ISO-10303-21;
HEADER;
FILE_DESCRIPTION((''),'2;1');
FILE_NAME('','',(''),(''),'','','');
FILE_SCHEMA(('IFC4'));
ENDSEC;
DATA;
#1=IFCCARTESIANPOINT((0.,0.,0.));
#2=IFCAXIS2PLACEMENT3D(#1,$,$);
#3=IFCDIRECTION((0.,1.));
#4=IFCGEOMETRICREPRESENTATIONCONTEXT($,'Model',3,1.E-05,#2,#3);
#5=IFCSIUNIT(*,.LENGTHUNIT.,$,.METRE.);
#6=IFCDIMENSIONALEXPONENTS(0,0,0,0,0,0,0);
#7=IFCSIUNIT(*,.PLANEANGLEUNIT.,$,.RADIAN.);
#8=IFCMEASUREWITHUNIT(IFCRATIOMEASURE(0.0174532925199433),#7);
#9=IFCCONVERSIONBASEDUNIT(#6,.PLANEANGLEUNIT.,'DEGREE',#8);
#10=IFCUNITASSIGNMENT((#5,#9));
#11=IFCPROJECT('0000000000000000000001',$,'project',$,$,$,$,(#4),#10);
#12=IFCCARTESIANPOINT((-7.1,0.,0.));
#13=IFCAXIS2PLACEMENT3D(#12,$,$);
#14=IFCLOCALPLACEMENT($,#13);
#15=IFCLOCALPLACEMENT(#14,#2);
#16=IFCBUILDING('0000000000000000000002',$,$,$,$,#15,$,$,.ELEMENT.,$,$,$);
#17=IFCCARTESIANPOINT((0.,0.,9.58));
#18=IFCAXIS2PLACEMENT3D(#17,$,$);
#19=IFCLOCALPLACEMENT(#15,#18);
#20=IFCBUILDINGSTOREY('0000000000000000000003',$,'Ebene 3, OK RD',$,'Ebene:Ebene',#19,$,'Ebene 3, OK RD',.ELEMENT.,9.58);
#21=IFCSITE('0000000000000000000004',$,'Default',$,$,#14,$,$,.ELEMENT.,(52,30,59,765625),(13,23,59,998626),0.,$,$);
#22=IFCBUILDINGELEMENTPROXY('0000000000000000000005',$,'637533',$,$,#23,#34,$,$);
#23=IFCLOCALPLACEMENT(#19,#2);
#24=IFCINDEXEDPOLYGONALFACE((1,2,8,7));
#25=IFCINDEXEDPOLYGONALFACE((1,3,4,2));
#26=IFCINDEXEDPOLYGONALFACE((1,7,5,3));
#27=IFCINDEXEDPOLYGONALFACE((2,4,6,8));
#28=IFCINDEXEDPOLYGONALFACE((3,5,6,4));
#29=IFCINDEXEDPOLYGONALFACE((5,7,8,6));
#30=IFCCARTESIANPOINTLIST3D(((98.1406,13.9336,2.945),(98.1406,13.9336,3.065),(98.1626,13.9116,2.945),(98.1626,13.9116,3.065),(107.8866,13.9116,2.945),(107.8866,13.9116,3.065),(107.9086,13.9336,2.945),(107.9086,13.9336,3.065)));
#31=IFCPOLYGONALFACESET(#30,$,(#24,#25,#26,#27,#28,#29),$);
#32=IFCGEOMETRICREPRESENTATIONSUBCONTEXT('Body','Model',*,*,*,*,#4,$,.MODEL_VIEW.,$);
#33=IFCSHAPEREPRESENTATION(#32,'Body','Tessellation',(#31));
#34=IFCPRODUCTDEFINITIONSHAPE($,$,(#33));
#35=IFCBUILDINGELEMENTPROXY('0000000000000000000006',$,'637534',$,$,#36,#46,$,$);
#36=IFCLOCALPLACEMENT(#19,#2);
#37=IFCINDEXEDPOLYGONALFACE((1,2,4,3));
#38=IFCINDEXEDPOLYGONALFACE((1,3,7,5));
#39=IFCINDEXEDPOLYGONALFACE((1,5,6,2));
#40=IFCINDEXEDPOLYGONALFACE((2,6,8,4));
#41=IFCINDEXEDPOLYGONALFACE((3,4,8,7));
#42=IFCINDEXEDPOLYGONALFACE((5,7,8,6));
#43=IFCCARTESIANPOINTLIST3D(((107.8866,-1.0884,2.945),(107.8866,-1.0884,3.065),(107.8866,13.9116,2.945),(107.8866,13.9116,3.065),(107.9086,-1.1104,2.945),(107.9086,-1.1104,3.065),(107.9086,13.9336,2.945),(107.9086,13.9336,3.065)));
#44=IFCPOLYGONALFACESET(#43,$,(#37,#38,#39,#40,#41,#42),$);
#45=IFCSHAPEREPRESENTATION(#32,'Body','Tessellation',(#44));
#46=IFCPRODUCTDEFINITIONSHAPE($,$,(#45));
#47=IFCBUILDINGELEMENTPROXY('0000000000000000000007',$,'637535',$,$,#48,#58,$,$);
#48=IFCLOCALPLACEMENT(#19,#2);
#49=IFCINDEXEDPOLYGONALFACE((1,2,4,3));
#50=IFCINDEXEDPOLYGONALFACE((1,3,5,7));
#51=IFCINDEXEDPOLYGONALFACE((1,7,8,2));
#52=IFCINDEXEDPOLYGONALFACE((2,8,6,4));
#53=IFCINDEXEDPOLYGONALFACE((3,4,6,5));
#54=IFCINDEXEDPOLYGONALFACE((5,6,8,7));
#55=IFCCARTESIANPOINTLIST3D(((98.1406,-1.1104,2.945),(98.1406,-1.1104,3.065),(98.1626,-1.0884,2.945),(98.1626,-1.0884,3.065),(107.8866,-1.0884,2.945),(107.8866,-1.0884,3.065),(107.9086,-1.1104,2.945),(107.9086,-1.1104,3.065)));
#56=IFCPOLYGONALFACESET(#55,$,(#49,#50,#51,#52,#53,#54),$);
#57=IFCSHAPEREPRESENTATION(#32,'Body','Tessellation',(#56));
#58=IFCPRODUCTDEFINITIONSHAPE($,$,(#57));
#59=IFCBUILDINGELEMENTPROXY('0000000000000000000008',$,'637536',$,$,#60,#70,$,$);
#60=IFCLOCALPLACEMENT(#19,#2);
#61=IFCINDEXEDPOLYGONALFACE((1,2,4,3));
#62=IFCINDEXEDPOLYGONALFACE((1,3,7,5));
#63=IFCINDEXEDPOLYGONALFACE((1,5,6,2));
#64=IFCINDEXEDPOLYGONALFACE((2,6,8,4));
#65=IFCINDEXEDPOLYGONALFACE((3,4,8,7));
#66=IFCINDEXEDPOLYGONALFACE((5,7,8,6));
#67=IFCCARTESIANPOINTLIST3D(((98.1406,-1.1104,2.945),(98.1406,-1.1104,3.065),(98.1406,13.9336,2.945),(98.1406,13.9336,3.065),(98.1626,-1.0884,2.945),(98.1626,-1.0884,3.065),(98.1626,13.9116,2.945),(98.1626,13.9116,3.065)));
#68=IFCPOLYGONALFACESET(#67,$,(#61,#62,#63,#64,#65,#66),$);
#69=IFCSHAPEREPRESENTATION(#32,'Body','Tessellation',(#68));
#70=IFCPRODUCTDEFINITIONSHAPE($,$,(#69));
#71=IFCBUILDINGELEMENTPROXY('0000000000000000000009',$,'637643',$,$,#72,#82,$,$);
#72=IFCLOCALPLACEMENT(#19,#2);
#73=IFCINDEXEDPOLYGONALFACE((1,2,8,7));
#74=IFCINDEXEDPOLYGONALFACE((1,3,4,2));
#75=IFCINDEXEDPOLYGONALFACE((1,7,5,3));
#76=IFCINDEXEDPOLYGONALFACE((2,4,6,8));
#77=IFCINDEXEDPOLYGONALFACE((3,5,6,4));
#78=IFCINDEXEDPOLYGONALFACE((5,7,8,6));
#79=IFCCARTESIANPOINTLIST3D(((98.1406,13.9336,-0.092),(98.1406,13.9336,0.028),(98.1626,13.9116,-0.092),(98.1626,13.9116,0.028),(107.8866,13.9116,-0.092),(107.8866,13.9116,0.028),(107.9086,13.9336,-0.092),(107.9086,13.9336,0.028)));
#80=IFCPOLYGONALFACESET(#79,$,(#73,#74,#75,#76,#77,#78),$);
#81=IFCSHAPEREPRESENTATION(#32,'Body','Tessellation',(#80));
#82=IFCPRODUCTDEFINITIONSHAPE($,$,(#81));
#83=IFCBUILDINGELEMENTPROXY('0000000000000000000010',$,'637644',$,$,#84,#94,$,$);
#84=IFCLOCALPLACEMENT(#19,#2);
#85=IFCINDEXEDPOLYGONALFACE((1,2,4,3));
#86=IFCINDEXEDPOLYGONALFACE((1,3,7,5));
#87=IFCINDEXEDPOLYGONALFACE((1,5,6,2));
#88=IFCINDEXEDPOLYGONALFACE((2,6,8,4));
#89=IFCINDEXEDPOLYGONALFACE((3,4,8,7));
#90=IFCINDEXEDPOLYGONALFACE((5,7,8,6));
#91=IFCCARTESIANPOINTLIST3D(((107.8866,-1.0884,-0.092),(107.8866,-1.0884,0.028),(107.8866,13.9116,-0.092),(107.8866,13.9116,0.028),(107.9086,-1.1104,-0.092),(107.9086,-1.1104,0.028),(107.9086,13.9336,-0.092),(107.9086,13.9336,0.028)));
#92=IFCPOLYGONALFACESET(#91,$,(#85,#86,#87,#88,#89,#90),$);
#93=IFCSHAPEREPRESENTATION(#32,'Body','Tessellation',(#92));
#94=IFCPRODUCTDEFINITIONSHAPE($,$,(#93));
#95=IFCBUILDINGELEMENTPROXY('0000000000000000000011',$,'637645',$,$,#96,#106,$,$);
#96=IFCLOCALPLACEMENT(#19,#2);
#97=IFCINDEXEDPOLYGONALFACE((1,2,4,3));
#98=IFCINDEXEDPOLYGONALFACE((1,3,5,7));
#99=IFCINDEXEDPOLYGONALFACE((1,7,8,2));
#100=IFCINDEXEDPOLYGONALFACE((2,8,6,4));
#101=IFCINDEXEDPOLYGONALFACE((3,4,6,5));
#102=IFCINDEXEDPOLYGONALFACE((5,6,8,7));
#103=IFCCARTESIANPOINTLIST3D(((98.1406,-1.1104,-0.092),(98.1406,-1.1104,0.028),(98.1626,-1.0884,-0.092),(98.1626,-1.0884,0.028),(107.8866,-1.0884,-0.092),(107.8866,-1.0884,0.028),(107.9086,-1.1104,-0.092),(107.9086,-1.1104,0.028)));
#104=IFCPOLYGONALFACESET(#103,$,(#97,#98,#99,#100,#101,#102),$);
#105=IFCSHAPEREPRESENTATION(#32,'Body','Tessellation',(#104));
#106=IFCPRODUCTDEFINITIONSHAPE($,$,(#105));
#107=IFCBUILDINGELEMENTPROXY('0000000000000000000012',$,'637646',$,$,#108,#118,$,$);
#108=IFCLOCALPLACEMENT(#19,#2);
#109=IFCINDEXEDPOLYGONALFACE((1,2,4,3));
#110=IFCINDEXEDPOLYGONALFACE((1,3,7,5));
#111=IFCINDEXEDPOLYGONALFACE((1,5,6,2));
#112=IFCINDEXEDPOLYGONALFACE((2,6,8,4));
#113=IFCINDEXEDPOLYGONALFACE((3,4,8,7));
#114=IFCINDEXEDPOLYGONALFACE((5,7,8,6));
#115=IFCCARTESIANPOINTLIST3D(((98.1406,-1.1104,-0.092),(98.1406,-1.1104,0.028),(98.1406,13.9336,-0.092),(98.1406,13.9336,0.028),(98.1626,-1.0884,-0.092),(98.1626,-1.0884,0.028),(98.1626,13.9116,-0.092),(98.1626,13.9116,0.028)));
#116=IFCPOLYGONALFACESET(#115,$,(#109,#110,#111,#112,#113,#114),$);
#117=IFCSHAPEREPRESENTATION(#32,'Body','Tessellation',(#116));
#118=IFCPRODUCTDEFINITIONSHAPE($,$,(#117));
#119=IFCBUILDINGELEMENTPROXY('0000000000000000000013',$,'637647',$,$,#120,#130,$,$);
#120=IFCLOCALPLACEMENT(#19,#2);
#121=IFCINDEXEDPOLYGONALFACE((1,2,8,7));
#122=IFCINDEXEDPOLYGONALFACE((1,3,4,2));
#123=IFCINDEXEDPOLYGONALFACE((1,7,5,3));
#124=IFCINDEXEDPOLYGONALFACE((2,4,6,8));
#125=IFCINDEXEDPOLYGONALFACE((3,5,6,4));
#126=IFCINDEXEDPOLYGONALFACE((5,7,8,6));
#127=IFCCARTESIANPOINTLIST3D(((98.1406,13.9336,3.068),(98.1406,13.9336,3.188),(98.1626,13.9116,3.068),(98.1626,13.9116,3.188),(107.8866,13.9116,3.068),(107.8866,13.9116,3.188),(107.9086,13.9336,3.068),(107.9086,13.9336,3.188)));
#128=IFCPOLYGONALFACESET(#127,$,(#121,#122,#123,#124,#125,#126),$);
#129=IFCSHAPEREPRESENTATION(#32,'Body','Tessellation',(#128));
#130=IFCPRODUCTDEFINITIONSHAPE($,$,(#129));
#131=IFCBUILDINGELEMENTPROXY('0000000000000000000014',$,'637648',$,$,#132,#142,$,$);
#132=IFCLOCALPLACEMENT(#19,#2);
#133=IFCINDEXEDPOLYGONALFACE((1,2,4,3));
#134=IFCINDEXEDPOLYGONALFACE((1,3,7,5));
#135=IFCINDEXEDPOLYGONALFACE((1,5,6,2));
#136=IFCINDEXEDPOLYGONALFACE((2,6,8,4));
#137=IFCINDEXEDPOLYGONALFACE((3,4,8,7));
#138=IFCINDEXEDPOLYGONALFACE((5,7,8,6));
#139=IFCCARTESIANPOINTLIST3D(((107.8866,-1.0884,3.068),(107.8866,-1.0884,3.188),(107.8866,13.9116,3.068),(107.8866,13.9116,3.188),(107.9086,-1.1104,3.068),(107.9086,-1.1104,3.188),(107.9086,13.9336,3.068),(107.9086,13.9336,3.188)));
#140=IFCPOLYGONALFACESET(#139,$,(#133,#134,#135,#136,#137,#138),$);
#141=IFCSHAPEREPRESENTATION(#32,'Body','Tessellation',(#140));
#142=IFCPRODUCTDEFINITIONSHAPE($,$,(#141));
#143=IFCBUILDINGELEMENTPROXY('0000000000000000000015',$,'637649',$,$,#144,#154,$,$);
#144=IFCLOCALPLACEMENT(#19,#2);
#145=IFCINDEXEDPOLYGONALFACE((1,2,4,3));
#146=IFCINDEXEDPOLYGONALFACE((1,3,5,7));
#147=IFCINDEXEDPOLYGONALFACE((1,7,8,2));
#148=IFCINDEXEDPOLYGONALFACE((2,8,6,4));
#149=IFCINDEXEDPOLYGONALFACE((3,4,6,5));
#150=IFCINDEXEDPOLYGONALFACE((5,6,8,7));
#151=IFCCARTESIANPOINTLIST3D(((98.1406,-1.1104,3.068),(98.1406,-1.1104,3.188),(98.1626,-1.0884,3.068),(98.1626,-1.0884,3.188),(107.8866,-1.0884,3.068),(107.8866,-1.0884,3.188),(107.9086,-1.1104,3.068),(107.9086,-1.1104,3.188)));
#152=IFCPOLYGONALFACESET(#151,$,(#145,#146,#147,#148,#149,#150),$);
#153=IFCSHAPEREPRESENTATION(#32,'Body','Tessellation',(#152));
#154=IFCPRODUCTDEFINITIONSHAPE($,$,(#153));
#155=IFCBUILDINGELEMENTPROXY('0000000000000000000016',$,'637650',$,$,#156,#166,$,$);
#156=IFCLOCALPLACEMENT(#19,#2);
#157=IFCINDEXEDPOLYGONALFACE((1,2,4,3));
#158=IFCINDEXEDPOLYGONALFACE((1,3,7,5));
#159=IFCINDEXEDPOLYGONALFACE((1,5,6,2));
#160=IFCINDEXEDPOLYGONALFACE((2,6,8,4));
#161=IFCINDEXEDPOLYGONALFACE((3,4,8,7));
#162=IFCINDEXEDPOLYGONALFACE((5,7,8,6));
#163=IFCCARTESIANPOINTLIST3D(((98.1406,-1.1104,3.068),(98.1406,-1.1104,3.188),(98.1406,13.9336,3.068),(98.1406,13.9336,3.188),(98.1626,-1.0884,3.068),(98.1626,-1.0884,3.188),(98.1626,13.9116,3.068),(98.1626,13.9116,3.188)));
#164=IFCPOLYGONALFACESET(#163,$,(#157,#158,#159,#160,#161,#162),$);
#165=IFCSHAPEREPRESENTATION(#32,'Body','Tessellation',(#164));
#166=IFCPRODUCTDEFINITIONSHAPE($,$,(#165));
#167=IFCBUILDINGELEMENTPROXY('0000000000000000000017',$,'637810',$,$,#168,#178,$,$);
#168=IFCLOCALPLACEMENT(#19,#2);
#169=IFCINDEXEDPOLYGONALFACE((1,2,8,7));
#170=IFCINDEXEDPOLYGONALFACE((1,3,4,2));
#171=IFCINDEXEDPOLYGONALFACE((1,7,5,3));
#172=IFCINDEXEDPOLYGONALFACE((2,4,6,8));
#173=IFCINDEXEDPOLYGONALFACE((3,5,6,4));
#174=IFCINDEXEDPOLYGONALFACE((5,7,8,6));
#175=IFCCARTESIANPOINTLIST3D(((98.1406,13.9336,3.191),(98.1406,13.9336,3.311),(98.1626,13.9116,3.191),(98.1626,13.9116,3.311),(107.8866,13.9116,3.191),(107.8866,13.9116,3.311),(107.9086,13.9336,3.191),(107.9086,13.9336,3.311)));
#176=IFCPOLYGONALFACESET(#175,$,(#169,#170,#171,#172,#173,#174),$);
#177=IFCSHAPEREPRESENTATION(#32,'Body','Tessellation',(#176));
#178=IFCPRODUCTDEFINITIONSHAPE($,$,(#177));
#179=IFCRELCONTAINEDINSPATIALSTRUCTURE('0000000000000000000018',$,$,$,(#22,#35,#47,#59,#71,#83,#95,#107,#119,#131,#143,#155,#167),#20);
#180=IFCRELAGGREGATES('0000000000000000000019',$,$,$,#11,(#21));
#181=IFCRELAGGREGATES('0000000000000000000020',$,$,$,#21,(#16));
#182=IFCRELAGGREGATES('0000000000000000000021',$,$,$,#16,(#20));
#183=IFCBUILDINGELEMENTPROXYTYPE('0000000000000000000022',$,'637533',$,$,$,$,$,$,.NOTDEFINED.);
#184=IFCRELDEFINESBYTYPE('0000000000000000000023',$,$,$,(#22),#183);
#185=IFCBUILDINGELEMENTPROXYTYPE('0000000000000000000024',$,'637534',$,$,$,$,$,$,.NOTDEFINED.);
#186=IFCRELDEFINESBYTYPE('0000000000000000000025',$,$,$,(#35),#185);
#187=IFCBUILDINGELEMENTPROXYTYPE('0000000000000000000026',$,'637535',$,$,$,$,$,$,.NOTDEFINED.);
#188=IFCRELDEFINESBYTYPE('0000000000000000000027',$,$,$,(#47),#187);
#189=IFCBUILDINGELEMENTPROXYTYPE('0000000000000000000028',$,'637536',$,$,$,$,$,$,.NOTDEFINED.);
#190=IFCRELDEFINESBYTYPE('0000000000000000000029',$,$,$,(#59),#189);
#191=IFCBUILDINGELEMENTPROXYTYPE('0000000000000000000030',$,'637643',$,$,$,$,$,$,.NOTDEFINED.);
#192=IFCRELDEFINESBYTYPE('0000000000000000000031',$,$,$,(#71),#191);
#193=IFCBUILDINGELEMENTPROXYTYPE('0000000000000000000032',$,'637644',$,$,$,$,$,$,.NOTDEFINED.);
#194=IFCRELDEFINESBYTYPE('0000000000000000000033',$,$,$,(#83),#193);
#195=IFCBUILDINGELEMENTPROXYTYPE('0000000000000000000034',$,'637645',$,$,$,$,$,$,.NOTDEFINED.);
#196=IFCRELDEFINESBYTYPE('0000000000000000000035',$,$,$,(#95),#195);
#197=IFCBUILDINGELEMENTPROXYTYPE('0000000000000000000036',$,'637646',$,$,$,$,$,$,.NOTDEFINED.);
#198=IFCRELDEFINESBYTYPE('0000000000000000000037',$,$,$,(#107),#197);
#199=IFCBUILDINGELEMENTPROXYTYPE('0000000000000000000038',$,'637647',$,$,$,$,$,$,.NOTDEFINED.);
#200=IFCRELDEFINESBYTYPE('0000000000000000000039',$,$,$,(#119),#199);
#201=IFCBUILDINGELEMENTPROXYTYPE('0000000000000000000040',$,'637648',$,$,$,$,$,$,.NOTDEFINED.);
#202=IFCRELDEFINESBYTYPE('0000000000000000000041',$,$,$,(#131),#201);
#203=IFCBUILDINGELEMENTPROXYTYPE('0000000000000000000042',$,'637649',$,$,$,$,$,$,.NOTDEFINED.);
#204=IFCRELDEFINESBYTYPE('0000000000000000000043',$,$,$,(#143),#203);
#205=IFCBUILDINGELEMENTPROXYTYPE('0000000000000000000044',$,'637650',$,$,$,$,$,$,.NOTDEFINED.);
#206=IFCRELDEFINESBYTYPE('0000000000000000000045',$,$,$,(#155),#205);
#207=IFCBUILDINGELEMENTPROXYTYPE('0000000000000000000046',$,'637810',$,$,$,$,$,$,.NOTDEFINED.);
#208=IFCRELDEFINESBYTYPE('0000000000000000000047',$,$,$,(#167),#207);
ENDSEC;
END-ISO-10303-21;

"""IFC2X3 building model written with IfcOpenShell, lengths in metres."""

from ifc_helpers import new_model, entity, si_unit, converted_unit, direction, frame, origin, place, context, subcontext, project, spatial, polyline, outline, extrude, type_object, element, save


model = new_model("IFC2X3")

# Units and contexts
model_context = context("Model", 3, precision=1e-05, world=origin(), true_north=direction((0.0, 1.0)))
body_context = subcontext(model_context, "Body", "Model", "MODEL_VIEW")
ifc_project = project(units=[si_unit("LENGTHUNIT", "METRE"), converted_unit("PLANEANGLEUNIT", "DEGREE", entity("IfcRatioMeasure", 0.0174532925199433), si_unit("PLANEANGLEUNIT", "RADIAN"), dimensions=[0, 0, 0, 0, 0, 0, 0])], contexts=[model_context])

# Site, building, storey
site_placement = place(None, frame((-7.1, 0.0, 0.0)))
site = spatial("IfcSite", under=ifc_project, at=site_placement, Name="Default", CompositionType="ELEMENT", RefLatitude=(52, 30, 59, 765625), RefLongitude=(13, 23, 59, 998626), RefElevation=0.0)
building_placement = place(site_placement, origin())
building = spatial("IfcBuilding", under=site, at=building_placement, CompositionType="ELEMENT")
storey_placement = place(building_placement, frame((0.0, 0.0, 9.58)))
storey = spatial("IfcBuildingStorey", under=building, at=storey_placement, Name="Ebene 3, OK RD", ObjectType="Ebene:Ebene", LongName="Ebene 3, OK RD", CompositionType="ELEMENT", Elevation=9.58)

# Building element proxies
building_element_proxy_type_1 = type_object("IfcBuildingElementProxyType", Name="637533", PredefinedType="NOTDEFINED")
proxy_1_placement = place(storey_placement, origin())
element("IfcBuildingElementProxy", 1, at=proxy_1_placement, inside=storey, type_object=building_element_proxy_type_1, Name="637533", context=body_context, shape_type="SweptSolid", body=[
    extrude(outline(polyline([(-4.862, -0.011), (4.862, -0.011), (4.884, 0.011), (-4.884, 0.011), (-4.862, -0.011)])), frame((103.0246, 13.9226, 2.945)), (0.0, 0.0, 1.0), 0.12),
])
building_element_proxy_type_2 = type_object("IfcBuildingElementProxyType", Name="637534", PredefinedType="NOTDEFINED")
proxy_2_placement = place(storey_placement, origin())
element("IfcBuildingElementProxy", 2, at=proxy_2_placement, inside=storey, type_object=building_element_proxy_type_2, Name="637534", context=body_context, shape_type="SweptSolid", body=[
    extrude(outline(polyline([(-7.5, -0.011), (7.5, -0.011), (7.522, 0.011), (-7.522, 0.011), (-7.5, -0.011)])), frame((107.8976, 6.4116, 2.945), z_axis=(0.0, 0.0, 1.0), x_axis=(0.0, -1.0, 0.0)), (0.0, 0.0, 1.0), 0.12),
])
building_element_proxy_type_3 = type_object("IfcBuildingElementProxyType", Name="637535", PredefinedType="NOTDEFINED")
proxy_3_placement = place(storey_placement, origin())
element("IfcBuildingElementProxy", 3, at=proxy_3_placement, inside=storey, type_object=building_element_proxy_type_3, Name="637535", context=body_context, shape_type="SweptSolid", body=[
    extrude(outline(polyline([(-4.862, -0.011), (4.862, -0.011), (4.884, 0.011), (-4.884, 0.011), (-4.862, -0.011)])), frame((103.0246, -1.0994, 2.945), z_axis=(0.0, 0.0, 1.0), x_axis=(-1.0, 0.0, 0.0)), (0.0, 0.0, 1.0), 0.12),
])
building_element_proxy_type_4 = type_object("IfcBuildingElementProxyType", Name="637536", PredefinedType="NOTDEFINED")
proxy_4_placement = place(storey_placement, origin())
element("IfcBuildingElementProxy", 4, at=proxy_4_placement, inside=storey, type_object=building_element_proxy_type_4, Name="637536", context=body_context, shape_type="SweptSolid", body=[
    extrude(outline(polyline([(-7.5, -0.011), (7.5, -0.011), (7.522, 0.011), (-7.522, 0.011), (-7.5, -0.011)])), frame((98.1516, 6.4116, 2.945), z_axis=(0.0, 0.0, 1.0), x_axis=(0.0, 1.0, 0.0)), (0.0, 0.0, 1.0), 0.12),
])
building_element_proxy_type_5 = type_object("IfcBuildingElementProxyType", Name="637643", PredefinedType="NOTDEFINED")
proxy_5_placement = place(storey_placement, origin())
element("IfcBuildingElementProxy", 5, at=proxy_5_placement, inside=storey, type_object=building_element_proxy_type_5, Name="637643", context=body_context, shape_type="SweptSolid", body=[
    extrude(outline(polyline([(-4.862, -0.011), (4.862, -0.011), (4.884, 0.011), (-4.884, 0.011), (-4.862, -0.011)])), frame((103.0246, 13.9226, -0.092)), (0.0, 0.0, 1.0), 0.12),
])
building_element_proxy_type_6 = type_object("IfcBuildingElementProxyType", Name="637644", PredefinedType="NOTDEFINED")
proxy_6_placement = place(storey_placement, origin())
element("IfcBuildingElementProxy", 6, at=proxy_6_placement, inside=storey, type_object=building_element_proxy_type_6, Name="637644", context=body_context, shape_type="SweptSolid", body=[
    extrude(outline(polyline([(-7.5, -0.011), (7.5, -0.011), (7.522, 0.011), (-7.522, 0.011), (-7.5, -0.011)])), frame((107.8976, 6.4116, -0.092), z_axis=(0.0, 0.0, 1.0), x_axis=(0.0, -1.0, 0.0)), (0.0, 0.0, 1.0), 0.12),
])
building_element_proxy_type_7 = type_object("IfcBuildingElementProxyType", Name="637645", PredefinedType="NOTDEFINED")
proxy_7_placement = place(storey_placement, origin())
element("IfcBuildingElementProxy", 7, at=proxy_7_placement, inside=storey, type_object=building_element_proxy_type_7, Name="637645", context=body_context, shape_type="SweptSolid", body=[
    extrude(outline(polyline([(-4.862, -0.011), (4.862, -0.011), (4.884, 0.011), (-4.884, 0.011), (-4.862, -0.011)])), frame((103.0246, -1.0994, -0.092), z_axis=(0.0, 0.0, 1.0), x_axis=(-1.0, 0.0, 0.0)), (0.0, 0.0, 1.0), 0.12),
])
building_element_proxy_type_8 = type_object("IfcBuildingElementProxyType", Name="637646", PredefinedType="NOTDEFINED")
proxy_8_placement = place(storey_placement, origin())
element("IfcBuildingElementProxy", 8, at=proxy_8_placement, inside=storey, type_object=building_element_proxy_type_8, Name="637646", context=body_context, shape_type="SweptSolid", body=[
    extrude(outline(polyline([(-7.5, -0.011), (7.5, -0.011), (7.522, 0.011), (-7.522, 0.011), (-7.5, -0.011)])), frame((98.1516, 6.4116, -0.092), z_axis=(0.0, 0.0, 1.0), x_axis=(0.0, 1.0, 0.0)), (0.0, 0.0, 1.0), 0.12),
])
building_element_proxy_type_9 = type_object("IfcBuildingElementProxyType", Name="637647", PredefinedType="NOTDEFINED")
proxy_9_placement = place(storey_placement, origin())
element("IfcBuildingElementProxy", 9, at=proxy_9_placement, inside=storey, type_object=building_element_proxy_type_9, Name="637647", context=body_context, shape_type="SweptSolid", body=[
    extrude(outline(polyline([(-4.862, -0.011), (4.862, -0.011), (4.884, 0.011), (-4.884, 0.011), (-4.862, -0.011)])), frame((103.0246, 13.9226, 3.068)), (0.0, 0.0, 1.0), 0.12),
])
building_element_proxy_type_10 = type_object("IfcBuildingElementProxyType", Name="637648", PredefinedType="NOTDEFINED")
proxy_10_placement = place(storey_placement, origin())
element("IfcBuildingElementProxy", 10, at=proxy_10_placement, inside=storey, type_object=building_element_proxy_type_10, Name="637648", context=body_context, shape_type="SweptSolid", body=[
    extrude(outline(polyline([(-7.5, -0.011), (7.5, -0.011), (7.522, 0.011), (-7.522, 0.011), (-7.5, -0.011)])), frame((107.8976, 6.4116, 3.068), z_axis=(0.0, 0.0, 1.0), x_axis=(0.0, -1.0, 0.0)), (0.0, 0.0, 1.0), 0.12),
])
building_element_proxy_type_11 = type_object("IfcBuildingElementProxyType", Name="637649", PredefinedType="NOTDEFINED")
proxy_11_placement = place(storey_placement, origin())
element("IfcBuildingElementProxy", 11, at=proxy_11_placement, inside=storey, type_object=building_element_proxy_type_11, Name="637649", context=body_context, shape_type="SweptSolid", body=[
    extrude(outline(polyline([(-4.862, -0.011), (4.862, -0.011), (4.884, 0.011), (-4.884, 0.011), (-4.862, -0.011)])), frame((103.0246, -1.0994, 3.068), z_axis=(0.0, 0.0, 1.0), x_axis=(-1.0, 0.0, 0.0)), (0.0, 0.0, 1.0), 0.12),
])
building_element_proxy_type_12 = type_object("IfcBuildingElementProxyType", Name="637650", PredefinedType="NOTDEFINED")
proxy_12_placement = place(storey_placement, origin())
element("IfcBuildingElementProxy", 12, at=proxy_12_placement, inside=storey, type_object=building_element_proxy_type_12, Name="637650", context=body_context, shape_type="SweptSolid", body=[
    extrude(outline(polyline([(-7.5, -0.011), (7.5, -0.011), (7.522, 0.011), (-7.522, 0.011), (-7.5, -0.011)])), frame((98.1516, 6.4116, 3.068), z_axis=(0.0, 0.0, 1.0), x_axis=(0.0, 1.0, 0.0)), (0.0, 0.0, 1.0), 0.12),
])
building_element_proxy_type_13 = type_object("IfcBuildingElementProxyType", Name="637810", PredefinedType="NOTDEFINED")
proxy_13_placement = place(storey_placement, origin())
element("IfcBuildingElementProxy", 13, at=proxy_13_placement, inside=storey, type_object=building_element_proxy_type_13, Name="637810", context=body_context, shape_type="SweptSolid", body=[
    extrude(outline(polyline([(-4.862, -0.011), (4.862, -0.011), (4.884, 0.011), (-4.884, 0.011), (-4.862, -0.011)])), frame((103.0246, 13.9226, 3.191)), (0.0, 0.0, 1.0), 0.12),
])

save(model, "model.ifc")
